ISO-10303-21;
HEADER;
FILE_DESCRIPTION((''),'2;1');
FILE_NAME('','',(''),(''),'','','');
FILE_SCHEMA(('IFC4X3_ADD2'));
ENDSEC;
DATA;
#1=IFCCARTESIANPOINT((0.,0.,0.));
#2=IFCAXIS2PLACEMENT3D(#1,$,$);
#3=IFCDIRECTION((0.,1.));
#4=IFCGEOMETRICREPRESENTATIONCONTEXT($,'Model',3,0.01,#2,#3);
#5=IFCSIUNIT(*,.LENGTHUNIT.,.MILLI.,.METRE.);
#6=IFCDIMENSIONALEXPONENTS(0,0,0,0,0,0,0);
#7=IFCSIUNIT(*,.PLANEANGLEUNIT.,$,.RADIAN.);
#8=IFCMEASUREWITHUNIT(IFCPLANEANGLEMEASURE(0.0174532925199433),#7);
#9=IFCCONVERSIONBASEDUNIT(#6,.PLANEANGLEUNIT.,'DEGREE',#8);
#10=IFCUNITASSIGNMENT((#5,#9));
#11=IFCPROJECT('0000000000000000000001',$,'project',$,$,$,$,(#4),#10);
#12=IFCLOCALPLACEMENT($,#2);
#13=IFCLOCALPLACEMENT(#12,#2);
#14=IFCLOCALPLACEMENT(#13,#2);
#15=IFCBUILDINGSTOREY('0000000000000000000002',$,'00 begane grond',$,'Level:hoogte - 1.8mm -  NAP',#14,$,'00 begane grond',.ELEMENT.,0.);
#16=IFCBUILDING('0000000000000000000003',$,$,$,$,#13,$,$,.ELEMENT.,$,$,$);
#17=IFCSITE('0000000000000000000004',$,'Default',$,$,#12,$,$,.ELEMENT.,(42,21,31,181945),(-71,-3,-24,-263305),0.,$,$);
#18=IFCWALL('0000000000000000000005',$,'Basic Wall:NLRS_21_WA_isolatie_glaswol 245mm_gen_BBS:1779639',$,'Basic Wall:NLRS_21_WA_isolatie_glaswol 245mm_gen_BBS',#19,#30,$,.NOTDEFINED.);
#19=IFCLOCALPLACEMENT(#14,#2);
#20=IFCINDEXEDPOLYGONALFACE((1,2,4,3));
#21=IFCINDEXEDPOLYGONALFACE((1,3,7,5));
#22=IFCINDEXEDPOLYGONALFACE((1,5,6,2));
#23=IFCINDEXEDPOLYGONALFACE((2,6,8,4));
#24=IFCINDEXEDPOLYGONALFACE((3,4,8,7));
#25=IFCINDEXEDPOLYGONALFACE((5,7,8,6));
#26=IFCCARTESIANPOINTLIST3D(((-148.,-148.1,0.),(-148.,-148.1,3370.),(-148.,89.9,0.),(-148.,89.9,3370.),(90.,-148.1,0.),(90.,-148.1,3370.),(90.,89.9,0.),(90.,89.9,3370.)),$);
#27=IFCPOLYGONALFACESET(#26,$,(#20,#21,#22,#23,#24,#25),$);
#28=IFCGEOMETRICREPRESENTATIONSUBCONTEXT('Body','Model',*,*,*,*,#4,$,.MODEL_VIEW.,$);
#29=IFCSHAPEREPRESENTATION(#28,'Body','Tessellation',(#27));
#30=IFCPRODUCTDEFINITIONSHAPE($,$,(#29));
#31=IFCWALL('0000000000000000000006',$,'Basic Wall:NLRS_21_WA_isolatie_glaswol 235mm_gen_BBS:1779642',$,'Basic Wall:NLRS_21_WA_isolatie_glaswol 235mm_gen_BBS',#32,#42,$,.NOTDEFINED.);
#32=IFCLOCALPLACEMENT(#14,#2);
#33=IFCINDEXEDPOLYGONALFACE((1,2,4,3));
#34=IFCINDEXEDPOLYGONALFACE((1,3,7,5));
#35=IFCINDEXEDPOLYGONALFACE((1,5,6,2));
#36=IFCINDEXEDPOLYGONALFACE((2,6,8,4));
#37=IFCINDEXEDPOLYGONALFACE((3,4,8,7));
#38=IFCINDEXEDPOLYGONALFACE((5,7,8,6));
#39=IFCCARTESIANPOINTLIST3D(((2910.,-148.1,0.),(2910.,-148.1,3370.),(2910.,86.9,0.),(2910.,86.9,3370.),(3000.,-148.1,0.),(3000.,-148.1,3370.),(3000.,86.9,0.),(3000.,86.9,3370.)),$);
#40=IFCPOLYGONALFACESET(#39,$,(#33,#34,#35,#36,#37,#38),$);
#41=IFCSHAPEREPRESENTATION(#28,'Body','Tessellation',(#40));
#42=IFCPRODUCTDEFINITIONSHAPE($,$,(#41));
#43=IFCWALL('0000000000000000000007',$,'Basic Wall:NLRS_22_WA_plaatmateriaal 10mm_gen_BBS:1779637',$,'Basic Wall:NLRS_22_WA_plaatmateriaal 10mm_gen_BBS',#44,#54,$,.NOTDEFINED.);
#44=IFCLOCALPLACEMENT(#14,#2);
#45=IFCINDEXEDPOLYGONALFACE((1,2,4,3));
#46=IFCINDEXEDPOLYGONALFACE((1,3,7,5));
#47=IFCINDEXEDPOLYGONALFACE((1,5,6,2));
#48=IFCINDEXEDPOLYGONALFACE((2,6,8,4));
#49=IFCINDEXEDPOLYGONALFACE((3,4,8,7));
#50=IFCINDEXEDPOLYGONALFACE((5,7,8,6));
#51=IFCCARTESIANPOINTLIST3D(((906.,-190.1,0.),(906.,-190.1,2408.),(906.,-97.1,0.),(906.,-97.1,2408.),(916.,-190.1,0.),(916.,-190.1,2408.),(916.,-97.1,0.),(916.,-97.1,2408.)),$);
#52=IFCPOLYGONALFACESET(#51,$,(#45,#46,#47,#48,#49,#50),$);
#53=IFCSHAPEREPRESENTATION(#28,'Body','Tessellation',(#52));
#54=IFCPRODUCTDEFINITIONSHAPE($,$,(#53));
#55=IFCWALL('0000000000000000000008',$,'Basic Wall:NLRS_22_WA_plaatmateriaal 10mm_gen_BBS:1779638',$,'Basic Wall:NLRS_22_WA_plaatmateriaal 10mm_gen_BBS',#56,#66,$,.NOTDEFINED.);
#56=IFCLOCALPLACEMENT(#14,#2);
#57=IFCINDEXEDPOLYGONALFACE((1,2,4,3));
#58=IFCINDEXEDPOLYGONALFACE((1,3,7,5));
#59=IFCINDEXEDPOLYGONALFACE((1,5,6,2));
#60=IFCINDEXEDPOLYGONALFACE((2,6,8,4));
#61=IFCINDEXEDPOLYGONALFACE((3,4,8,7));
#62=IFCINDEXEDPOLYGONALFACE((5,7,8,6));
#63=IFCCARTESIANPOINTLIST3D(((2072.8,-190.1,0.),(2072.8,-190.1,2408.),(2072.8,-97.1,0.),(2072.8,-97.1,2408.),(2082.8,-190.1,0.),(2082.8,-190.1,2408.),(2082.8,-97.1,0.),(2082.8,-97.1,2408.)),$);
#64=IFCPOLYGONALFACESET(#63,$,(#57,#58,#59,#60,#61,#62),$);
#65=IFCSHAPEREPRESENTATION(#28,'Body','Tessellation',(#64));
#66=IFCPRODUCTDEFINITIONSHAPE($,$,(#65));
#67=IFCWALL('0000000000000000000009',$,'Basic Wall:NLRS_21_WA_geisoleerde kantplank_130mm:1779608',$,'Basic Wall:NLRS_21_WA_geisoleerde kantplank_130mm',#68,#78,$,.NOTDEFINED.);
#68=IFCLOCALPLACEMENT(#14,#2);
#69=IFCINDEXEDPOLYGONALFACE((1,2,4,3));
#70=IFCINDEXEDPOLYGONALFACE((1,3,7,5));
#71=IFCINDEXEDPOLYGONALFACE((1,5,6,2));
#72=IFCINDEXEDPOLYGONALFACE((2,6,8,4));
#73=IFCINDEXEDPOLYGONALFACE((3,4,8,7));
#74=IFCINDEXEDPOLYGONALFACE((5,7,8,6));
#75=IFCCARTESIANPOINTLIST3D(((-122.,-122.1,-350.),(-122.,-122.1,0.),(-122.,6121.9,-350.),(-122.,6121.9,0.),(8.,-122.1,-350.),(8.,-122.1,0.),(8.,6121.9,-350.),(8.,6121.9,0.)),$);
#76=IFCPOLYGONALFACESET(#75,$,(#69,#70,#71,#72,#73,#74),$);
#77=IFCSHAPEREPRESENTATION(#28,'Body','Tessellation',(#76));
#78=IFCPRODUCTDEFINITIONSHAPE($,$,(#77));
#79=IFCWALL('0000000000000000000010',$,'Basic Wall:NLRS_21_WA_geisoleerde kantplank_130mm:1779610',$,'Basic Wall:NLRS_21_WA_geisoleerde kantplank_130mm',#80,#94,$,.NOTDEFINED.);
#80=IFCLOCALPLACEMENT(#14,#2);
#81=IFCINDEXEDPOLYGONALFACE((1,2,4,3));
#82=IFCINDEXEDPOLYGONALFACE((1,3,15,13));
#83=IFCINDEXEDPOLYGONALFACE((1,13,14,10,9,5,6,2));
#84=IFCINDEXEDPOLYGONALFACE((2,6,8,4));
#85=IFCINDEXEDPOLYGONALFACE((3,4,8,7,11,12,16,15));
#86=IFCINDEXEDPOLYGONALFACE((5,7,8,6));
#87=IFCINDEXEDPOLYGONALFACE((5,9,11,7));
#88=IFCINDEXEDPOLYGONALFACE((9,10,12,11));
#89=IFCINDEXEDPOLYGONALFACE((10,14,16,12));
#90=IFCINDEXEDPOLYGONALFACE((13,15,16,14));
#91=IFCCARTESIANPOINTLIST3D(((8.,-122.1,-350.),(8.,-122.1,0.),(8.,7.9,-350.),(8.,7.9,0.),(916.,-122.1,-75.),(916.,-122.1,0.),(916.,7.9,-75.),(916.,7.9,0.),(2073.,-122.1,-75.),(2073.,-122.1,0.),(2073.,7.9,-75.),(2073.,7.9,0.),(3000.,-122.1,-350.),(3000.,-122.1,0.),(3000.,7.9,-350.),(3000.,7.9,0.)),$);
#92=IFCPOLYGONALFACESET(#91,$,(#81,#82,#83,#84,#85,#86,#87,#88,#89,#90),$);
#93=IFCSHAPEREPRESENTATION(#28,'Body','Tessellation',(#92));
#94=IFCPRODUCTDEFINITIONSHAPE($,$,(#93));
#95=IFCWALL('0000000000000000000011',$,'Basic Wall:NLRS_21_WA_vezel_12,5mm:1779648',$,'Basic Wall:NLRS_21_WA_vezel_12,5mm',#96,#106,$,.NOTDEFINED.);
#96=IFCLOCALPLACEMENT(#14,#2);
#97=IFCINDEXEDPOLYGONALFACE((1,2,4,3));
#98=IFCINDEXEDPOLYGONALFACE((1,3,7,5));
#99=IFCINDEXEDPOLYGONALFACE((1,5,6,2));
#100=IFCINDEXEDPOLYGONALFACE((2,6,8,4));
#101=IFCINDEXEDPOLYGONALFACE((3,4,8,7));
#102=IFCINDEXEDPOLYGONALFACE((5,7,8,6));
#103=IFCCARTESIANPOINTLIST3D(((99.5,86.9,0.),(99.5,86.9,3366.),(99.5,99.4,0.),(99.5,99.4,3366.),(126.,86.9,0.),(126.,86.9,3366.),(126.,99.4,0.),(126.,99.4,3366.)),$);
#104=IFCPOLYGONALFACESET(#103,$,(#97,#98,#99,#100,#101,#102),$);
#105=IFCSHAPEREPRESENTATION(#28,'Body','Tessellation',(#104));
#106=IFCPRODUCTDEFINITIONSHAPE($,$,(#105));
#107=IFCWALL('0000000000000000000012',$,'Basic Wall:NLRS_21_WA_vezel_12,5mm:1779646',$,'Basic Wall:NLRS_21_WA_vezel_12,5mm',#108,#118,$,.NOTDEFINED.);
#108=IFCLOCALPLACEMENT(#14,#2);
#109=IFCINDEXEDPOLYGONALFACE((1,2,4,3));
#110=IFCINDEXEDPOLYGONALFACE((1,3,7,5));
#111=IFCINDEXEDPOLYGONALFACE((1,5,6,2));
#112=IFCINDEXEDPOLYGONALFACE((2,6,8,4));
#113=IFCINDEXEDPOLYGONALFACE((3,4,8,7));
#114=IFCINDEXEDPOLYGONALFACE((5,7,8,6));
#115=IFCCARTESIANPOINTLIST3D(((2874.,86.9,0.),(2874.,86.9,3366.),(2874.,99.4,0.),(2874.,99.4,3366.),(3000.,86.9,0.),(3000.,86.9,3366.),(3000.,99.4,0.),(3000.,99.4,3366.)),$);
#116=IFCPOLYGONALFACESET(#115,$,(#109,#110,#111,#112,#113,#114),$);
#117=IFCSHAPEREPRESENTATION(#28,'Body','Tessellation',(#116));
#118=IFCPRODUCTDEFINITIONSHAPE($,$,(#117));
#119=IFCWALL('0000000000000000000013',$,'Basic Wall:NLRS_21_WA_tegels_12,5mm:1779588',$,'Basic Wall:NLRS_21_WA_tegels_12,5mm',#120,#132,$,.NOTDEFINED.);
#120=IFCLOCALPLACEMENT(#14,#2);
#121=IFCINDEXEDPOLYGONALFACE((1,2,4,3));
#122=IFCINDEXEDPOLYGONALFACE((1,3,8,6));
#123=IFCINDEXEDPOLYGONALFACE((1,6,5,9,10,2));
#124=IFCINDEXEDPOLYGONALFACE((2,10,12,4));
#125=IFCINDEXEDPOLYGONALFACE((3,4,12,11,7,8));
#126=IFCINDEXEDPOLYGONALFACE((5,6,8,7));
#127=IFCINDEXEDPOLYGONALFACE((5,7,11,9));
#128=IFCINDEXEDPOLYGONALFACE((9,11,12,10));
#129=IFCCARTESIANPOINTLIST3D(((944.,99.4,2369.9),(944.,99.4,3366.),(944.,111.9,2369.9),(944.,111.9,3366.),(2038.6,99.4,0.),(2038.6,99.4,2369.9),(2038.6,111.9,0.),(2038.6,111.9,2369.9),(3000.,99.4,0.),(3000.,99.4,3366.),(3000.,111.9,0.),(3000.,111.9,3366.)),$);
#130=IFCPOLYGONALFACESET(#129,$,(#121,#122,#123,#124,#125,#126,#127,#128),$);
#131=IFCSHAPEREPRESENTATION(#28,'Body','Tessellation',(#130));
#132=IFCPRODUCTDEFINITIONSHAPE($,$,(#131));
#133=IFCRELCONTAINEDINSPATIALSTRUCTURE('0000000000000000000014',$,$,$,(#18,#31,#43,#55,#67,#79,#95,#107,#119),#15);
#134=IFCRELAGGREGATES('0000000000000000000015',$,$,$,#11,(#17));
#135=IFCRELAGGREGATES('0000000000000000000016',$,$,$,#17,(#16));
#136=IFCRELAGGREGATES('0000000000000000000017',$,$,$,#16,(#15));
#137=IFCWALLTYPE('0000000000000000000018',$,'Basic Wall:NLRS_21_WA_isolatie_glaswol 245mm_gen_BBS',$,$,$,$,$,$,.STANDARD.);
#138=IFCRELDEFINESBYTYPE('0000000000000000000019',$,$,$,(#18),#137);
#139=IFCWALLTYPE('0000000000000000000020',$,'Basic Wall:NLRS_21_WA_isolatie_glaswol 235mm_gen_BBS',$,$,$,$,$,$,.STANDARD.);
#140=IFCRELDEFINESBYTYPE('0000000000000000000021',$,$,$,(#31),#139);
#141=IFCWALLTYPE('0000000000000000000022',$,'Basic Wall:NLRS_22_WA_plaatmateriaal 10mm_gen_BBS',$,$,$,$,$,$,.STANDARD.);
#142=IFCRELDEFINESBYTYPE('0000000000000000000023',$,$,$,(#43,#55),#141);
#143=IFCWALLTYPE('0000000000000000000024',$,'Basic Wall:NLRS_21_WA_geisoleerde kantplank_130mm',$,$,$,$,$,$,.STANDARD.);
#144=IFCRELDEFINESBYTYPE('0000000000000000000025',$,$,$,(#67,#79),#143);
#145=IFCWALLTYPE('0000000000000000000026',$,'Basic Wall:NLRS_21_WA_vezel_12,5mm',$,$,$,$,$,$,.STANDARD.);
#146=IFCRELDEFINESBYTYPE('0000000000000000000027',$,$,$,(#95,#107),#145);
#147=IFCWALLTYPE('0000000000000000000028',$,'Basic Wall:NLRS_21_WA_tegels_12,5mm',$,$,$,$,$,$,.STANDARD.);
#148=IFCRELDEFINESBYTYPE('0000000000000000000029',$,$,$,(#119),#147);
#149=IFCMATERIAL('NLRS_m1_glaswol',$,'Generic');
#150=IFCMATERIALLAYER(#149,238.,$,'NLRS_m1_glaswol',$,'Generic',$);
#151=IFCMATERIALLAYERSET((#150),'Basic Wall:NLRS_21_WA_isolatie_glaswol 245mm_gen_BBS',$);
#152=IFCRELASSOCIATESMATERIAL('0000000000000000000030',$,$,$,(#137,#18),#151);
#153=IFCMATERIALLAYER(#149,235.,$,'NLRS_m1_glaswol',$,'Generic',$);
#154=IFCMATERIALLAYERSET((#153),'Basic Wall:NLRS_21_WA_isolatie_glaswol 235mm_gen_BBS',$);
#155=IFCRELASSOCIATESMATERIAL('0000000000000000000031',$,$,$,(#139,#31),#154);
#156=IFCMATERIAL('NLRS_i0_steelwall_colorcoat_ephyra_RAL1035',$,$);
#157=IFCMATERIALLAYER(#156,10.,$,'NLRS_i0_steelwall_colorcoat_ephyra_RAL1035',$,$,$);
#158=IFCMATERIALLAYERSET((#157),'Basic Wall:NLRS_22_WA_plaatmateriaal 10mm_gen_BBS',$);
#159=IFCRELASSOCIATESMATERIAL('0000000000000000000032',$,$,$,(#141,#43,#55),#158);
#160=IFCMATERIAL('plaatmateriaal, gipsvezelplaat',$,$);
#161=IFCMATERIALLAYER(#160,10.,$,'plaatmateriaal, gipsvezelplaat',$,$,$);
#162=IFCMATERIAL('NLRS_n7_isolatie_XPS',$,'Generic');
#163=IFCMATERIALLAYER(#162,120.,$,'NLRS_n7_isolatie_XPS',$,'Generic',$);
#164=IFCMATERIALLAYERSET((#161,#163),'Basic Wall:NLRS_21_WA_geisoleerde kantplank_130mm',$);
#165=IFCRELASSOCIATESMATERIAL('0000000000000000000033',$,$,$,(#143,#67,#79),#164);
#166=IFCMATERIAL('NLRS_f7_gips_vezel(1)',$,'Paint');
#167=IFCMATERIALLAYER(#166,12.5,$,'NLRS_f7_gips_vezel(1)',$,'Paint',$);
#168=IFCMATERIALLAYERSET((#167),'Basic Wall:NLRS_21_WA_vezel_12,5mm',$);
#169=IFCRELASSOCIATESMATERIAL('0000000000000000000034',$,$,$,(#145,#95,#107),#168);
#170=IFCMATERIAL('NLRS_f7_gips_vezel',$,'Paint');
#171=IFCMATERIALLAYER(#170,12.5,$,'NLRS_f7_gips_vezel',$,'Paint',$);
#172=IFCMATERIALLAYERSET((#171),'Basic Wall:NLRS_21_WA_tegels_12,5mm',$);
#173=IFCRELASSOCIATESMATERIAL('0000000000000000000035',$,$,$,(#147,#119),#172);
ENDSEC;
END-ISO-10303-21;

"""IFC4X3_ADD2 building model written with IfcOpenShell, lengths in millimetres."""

from ifc_helpers import new_model, entity, si_unit, converted_unit, direction, frame, frame_2d, origin, place, context, subcontext, project, spatial, rectangle, extrude, material, layer, layer_set, layer_usage, type_object, element, save


model = new_model("IFC4X3_ADD2")

# Units and contexts
model_context = context("Model", 3, precision=0.01, world=origin(), true_north=direction((0.0, 1.0)))
body_context = subcontext(model_context, "Body", "Model", "MODEL_VIEW")
ifc_project = project(units=[si_unit("LENGTHUNIT", "METRE", prefix="MILLI"), converted_unit("PLANEANGLEUNIT", "DEGREE", entity("IfcPlaneAngleMeasure", 0.0174532925199433), si_unit("PLANEANGLEUNIT", "RADIAN"), dimensions=[0, 0, 0, 0, 0, 0, 0])], contexts=[model_context])

# Site, building, storey
site_placement = place(None, origin())
site = spatial("IfcSite", under=ifc_project, at=site_placement, Name="Default", CompositionType="ELEMENT", RefLatitude=(42, 21, 31, 181945), RefLongitude=(-71, -3, -24, -263305), RefElevation=0.0)
building_placement = place(site_placement, origin())
building = spatial("IfcBuilding", under=site, at=building_placement, CompositionType="ELEMENT")
storey_placement = place(building_placement, origin())
storey = spatial("IfcBuildingStorey", under=building, at=storey_placement, Name="00 begane grond", ObjectType="Level:hoogte - 1.8mm -  NAP", LongName="00 begane grond", CompositionType="ELEMENT", Elevation=0.0)

# Walls
ifc_material_1 = material(Name="NLRS_m1_glaswol", Category="Generic")
ifc_layer_1 = layer(ifc_material_1, 238.0, Name="NLRS_m1_glaswol", Category="Generic")
ifc_layer_set_1 = layer_set([ifc_layer_1], Name="Basic Wall:NLRS_21_WA_isolatie_glaswol 245mm_gen_BBS")
ifc_layer_usage_1 = layer_usage(ifc_layer_set_1, "AXIS2", "POSITIVE", -119.0)
wall_type_1 = type_object("IfcWallType", Name="Basic Wall:NLRS_21_WA_isolatie_glaswol 245mm_gen_BBS", PredefinedType="STANDARD", material=ifc_layer_set_1)
wall_1_placement = place(storey_placement, frame((-29.0, -148.1, 0.0), z_axis=(0.0, 0.0, 1.0), x_axis=(0.0, 1.0, 0.0)))
element("IfcWall", 1, at=wall_1_placement, inside=storey, type_object=wall_type_1, material=ifc_layer_usage_1, Name="Basic Wall:NLRS_21_WA_isolatie_glaswol 245mm_gen_BBS:1779639", ObjectType="Basic Wall:NLRS_21_WA_isolatie_glaswol 245mm_gen_BBS", PredefinedType="NOTDEFINED", context=body_context, shape_type="SweptSolid", body=[
    extrude(rectangle(XDim=238.0, YDim=238.0, at=frame_2d((119.0, 0.0), x_axis=(-1.0, 0.0))), origin(), (0.0, 0.0, 1.0), 3370.0),
])
ifc_layer_2 = layer(ifc_material_1, 235.0, Name="NLRS_m1_glaswol", Category="Generic")
ifc_layer_set_2 = layer_set([ifc_layer_2], Name="Basic Wall:NLRS_21_WA_isolatie_glaswol 235mm_gen_BBS")
ifc_layer_usage_2 = layer_usage(ifc_layer_set_2, "AXIS2", "POSITIVE", -117.5)
wall_type_2 = type_object("IfcWallType", Name="Basic Wall:NLRS_21_WA_isolatie_glaswol 235mm_gen_BBS", PredefinedType="STANDARD", material=ifc_layer_set_2)
wall_2_placement = place(storey_placement, frame((2910.0, -30.6, 0.0)))
element("IfcWall", 2, at=wall_2_placement, inside=storey, type_object=wall_type_2, material=ifc_layer_usage_2, Name="Basic Wall:NLRS_21_WA_isolatie_glaswol 235mm_gen_BBS:1779642", ObjectType="Basic Wall:NLRS_21_WA_isolatie_glaswol 235mm_gen_BBS", PredefinedType="NOTDEFINED", context=body_context, shape_type="SweptSolid", body=[
    extrude(rectangle(XDim=90.0, YDim=235.0, at=frame_2d((45.0, 0.0), x_axis=(-1.0, 0.0))), origin(), (0.0, 0.0, 1.0), 3370.0),
])
ifc_material_2 = material(Name="NLRS_i0_steelwall_colorcoat_ephyra_RAL1035")
ifc_layer_3 = layer(ifc_material_2, 10.0, Name="NLRS_i0_steelwall_colorcoat_ephyra_RAL1035")
ifc_layer_set_3 = layer_set([ifc_layer_3], Name="Basic Wall:NLRS_22_WA_plaatmateriaal 10mm_gen_BBS")
ifc_layer_usage_3 = layer_usage(ifc_layer_set_3, "AXIS2", "POSITIVE", -5.0)
wall_type_3 = type_object("IfcWallType", Name="Basic Wall:NLRS_22_WA_plaatmateriaal 10mm_gen_BBS", PredefinedType="STANDARD", material=ifc_layer_set_3)
wall_3_placement = place(storey_placement, frame((911.0, -190.1, 0.0), z_axis=(0.0, 0.0, 1.0), x_axis=(0.0, 1.0, 0.0)))
element("IfcWall", 3, at=wall_3_placement, inside=storey, type_object=wall_type_3, material=ifc_layer_usage_3, Name="Basic Wall:NLRS_22_WA_plaatmateriaal 10mm_gen_BBS:1779637", ObjectType="Basic Wall:NLRS_22_WA_plaatmateriaal 10mm_gen_BBS", PredefinedType="NOTDEFINED", context=body_context, shape_type="SweptSolid", body=[
    extrude(rectangle(XDim=93.0, YDim=10.0, at=frame_2d((46.5, 0.0), x_axis=(-1.0, 0.0))), origin(), (0.0, 0.0, 1.0), 2408.0),
])
ifc_layer_usage_4 = layer_usage(ifc_layer_set_3, "AXIS2", "NEGATIVE", 5.0)
wall_4_placement = place(storey_placement, frame((2077.8, -190.1, 0.0), z_axis=(0.0, 0.0, 1.0), x_axis=(0.0, 1.0, 0.0)))
element("IfcWall", 4, at=wall_4_placement, inside=storey, type_object=wall_type_3, material=ifc_layer_usage_4, Name="Basic Wall:NLRS_22_WA_plaatmateriaal 10mm_gen_BBS:1779638", ObjectType="Basic Wall:NLRS_22_WA_plaatmateriaal 10mm_gen_BBS", PredefinedType="NOTDEFINED", context=body_context, shape_type="SweptSolid", body=[
    extrude(rectangle(XDim=93.0, YDim=10.0, at=frame_2d((46.5, 0.0), x_axis=(-1.0, 0.0))), origin(), (0.0, 0.0, 1.0), 2408.0),
])
ifc_material_3 = material(Name="plaatmateriaal, gipsvezelplaat")
ifc_layer_4 = layer(ifc_material_3, 10.0, Name="plaatmateriaal, gipsvezelplaat")
ifc_material_4 = material(Name="NLRS_n7_isolatie_XPS", Category="Generic")
ifc_layer_5 = layer(ifc_material_4, 120.0, Name="NLRS_n7_isolatie_XPS", Category="Generic")
ifc_layer_set_4 = layer_set([ifc_layer_4, ifc_layer_5], Name="Basic Wall:NLRS_21_WA_geisoleerde kantplank_130mm")
ifc_layer_usage_5 = layer_usage(ifc_layer_set_4, "AXIS2", "NEGATIVE", 65.0)
wall_type_4 = type_object("IfcWallType", Name="Basic Wall:NLRS_21_WA_geisoleerde kantplank_130mm", PredefinedType="STANDARD", material=ifc_layer_set_4)
wall_5_placement = place(storey_placement, frame((-57.0, -122.1, -350.0), z_axis=(0.0, 0.0, 1.0), x_axis=(0.0, 1.0, 0.0)))
element("IfcWall", 5, at=wall_5_placement, inside=storey, type_object=wall_type_4, material=ifc_layer_usage_5, Name="Basic Wall:NLRS_21_WA_geisoleerde kantplank_130mm:1779608", ObjectType="Basic Wall:NLRS_21_WA_geisoleerde kantplank_130mm", PredefinedType="NOTDEFINED", context=body_context, shape_type="SweptSolid", body=[
    extrude(rectangle(XDim=6244.1, YDim=130.0, at=frame_2d((3122.0, 0.0), x_axis=(-1.0, 0.0))), origin(), (0.0, 0.0, 1.0), 350.0),
])

# Wall, opening
ifc_layer_usage_6 = layer_usage(ifc_layer_set_4, "AXIS2", "POSITIVE", -65.0)
wall_6_placement = place(storey_placement, frame((8.0, -57.1, -350.0)))
wall_6 = element("IfcWall", 6, at=wall_6_placement, inside=storey, type_object=wall_type_4, material=ifc_layer_usage_6, Name="Basic Wall:NLRS_21_WA_geisoleerde kantplank_130mm:1779610", ObjectType="Basic Wall:NLRS_21_WA_geisoleerde kantplank_130mm", PredefinedType="NOTDEFINED", context=body_context, shape_type="SweptSolid", body=[
    extrude(rectangle(XDim=2992.0, YDim=130.0, at=frame_2d((1496.0, 0.0), x_axis=(-1.0, 0.0))), origin(), (0.0, 0.0, 1.0), 350.0),
])
opening_1_placement = place(wall_6_placement, origin())
element("IfcOpeningElement", 7, at=opening_1_placement, cuts=wall_6, PredefinedType="OPENING", context=body_context, shape_type="SweptSolid", body=[
    extrude(rectangle(XDim=75.0, YDim=1157.0, at=frame_2d((0.0, 0.0), x_axis=(0.0, 1.0))), frame((1486.5, 65.0, 312.5), z_axis=(0.0, -1.0, 0.0), x_axis=(-1.0, 0.0, 0.0)), (0.0, 0.0, 1.0), 130.0),
])

# Walls
ifc_material_5 = material(Name="NLRS_f7_gips_vezel(1)", Category="Paint")
ifc_layer_6 = layer(ifc_material_5, 12.5, Name="NLRS_f7_gips_vezel(1)", Category="Paint")
ifc_layer_set_5 = layer_set([ifc_layer_6], Name="Basic Wall:NLRS_21_WA_vezel_12,5mm")
ifc_layer_usage_7 = layer_usage(ifc_layer_set_5, "AXIS2", "NEGATIVE", 6.2)
wall_type_5 = type_object("IfcWallType", Name="Basic Wall:NLRS_21_WA_vezel_12,5mm", PredefinedType="STANDARD", material=ifc_layer_set_5)
wall_7_placement = place(storey_placement, frame((99.5, 93.2, 0.0)))
element("IfcWall", 8, at=wall_7_placement, inside=storey, type_object=wall_type_5, material=ifc_layer_usage_7, Name="Basic Wall:NLRS_21_WA_vezel_12,5mm:1779648", ObjectType="Basic Wall:NLRS_21_WA_vezel_12,5mm", PredefinedType="NOTDEFINED", context=body_context, shape_type="SweptSolid", body=[
    extrude(rectangle(XDim=26.5, YDim=12.5, at=frame_2d((13.2, 0.0), x_axis=(-1.0, 0.0))), origin(), (0.0, 0.0, 1.0), 3366.0),
])
ifc_layer_usage_8 = layer_usage(ifc_layer_set_5, "AXIS2", "NEGATIVE", 6.2)
wall_8_placement = place(storey_placement, frame((2874.0, 93.2, 0.0)))
element("IfcWall", 9, at=wall_8_placement, inside=storey, type_object=wall_type_5, material=ifc_layer_usage_8, Name="Basic Wall:NLRS_21_WA_vezel_12,5mm:1779646", ObjectType="Basic Wall:NLRS_21_WA_vezel_12,5mm", PredefinedType="NOTDEFINED", context=body_context, shape_type="SweptSolid", body=[
    extrude(rectangle(XDim=126.0, YDim=12.5, at=frame_2d((63.0, 0.0), x_axis=(-1.0, 0.0))), origin(), (0.0, 0.0, 1.0), 3366.0),
])

# Wall, opening
ifc_material_6 = material(Name="NLRS_f7_gips_vezel", Category="Paint")
ifc_layer_7 = layer(ifc_material_6, 12.5, Name="NLRS_f7_gips_vezel", Category="Paint")
ifc_layer_set_6 = layer_set([ifc_layer_7], Name="Basic Wall:NLRS_21_WA_tegels_12,5mm")
ifc_layer_usage_9 = layer_usage(ifc_layer_set_6, "AXIS2", "NEGATIVE", 6.2)
wall_type_6 = type_object("IfcWallType", Name="Basic Wall:NLRS_21_WA_tegels_12,5mm", PredefinedType="STANDARD", material=ifc_layer_set_6)
wall_9_placement = place(storey_placement, frame((944.0, 105.7, 0.0)))
wall_9 = element("IfcWall", 10, at=wall_9_placement, inside=storey, type_object=wall_type_6, material=ifc_layer_usage_9, Name="Basic Wall:NLRS_21_WA_tegels_12,5mm:1779588", ObjectType="Basic Wall:NLRS_21_WA_tegels_12,5mm", PredefinedType="NOTDEFINED", context=body_context, shape_type="SweptSolid", body=[
    extrude(rectangle(XDim=2056.0, YDim=12.5, at=frame_2d((1028.0, 0.0), x_axis=(-1.0, 0.0))), origin(), (0.0, 0.0, 1.0), 3366.0),
])
opening_2_placement = place(wall_9_placement, origin())
element("IfcOpeningElement", 11, at=opening_2_placement, cuts=wall_9, PredefinedType="OPENING", context=body_context, shape_type="SweptSolid", body=[
    extrude(rectangle(XDim=2369.9, YDim=1094.6, at=frame_2d((0.0, 0.0), x_axis=(1.0, 0.0))), frame((547.3, 6.2, 1184.9), z_axis=(0.0, -1.0, 0.0), x_axis=(0.0, 0.0, -1.0)), (0.0, 0.0, 1.0), 12.5),
])

save(model, "model.ifc")
